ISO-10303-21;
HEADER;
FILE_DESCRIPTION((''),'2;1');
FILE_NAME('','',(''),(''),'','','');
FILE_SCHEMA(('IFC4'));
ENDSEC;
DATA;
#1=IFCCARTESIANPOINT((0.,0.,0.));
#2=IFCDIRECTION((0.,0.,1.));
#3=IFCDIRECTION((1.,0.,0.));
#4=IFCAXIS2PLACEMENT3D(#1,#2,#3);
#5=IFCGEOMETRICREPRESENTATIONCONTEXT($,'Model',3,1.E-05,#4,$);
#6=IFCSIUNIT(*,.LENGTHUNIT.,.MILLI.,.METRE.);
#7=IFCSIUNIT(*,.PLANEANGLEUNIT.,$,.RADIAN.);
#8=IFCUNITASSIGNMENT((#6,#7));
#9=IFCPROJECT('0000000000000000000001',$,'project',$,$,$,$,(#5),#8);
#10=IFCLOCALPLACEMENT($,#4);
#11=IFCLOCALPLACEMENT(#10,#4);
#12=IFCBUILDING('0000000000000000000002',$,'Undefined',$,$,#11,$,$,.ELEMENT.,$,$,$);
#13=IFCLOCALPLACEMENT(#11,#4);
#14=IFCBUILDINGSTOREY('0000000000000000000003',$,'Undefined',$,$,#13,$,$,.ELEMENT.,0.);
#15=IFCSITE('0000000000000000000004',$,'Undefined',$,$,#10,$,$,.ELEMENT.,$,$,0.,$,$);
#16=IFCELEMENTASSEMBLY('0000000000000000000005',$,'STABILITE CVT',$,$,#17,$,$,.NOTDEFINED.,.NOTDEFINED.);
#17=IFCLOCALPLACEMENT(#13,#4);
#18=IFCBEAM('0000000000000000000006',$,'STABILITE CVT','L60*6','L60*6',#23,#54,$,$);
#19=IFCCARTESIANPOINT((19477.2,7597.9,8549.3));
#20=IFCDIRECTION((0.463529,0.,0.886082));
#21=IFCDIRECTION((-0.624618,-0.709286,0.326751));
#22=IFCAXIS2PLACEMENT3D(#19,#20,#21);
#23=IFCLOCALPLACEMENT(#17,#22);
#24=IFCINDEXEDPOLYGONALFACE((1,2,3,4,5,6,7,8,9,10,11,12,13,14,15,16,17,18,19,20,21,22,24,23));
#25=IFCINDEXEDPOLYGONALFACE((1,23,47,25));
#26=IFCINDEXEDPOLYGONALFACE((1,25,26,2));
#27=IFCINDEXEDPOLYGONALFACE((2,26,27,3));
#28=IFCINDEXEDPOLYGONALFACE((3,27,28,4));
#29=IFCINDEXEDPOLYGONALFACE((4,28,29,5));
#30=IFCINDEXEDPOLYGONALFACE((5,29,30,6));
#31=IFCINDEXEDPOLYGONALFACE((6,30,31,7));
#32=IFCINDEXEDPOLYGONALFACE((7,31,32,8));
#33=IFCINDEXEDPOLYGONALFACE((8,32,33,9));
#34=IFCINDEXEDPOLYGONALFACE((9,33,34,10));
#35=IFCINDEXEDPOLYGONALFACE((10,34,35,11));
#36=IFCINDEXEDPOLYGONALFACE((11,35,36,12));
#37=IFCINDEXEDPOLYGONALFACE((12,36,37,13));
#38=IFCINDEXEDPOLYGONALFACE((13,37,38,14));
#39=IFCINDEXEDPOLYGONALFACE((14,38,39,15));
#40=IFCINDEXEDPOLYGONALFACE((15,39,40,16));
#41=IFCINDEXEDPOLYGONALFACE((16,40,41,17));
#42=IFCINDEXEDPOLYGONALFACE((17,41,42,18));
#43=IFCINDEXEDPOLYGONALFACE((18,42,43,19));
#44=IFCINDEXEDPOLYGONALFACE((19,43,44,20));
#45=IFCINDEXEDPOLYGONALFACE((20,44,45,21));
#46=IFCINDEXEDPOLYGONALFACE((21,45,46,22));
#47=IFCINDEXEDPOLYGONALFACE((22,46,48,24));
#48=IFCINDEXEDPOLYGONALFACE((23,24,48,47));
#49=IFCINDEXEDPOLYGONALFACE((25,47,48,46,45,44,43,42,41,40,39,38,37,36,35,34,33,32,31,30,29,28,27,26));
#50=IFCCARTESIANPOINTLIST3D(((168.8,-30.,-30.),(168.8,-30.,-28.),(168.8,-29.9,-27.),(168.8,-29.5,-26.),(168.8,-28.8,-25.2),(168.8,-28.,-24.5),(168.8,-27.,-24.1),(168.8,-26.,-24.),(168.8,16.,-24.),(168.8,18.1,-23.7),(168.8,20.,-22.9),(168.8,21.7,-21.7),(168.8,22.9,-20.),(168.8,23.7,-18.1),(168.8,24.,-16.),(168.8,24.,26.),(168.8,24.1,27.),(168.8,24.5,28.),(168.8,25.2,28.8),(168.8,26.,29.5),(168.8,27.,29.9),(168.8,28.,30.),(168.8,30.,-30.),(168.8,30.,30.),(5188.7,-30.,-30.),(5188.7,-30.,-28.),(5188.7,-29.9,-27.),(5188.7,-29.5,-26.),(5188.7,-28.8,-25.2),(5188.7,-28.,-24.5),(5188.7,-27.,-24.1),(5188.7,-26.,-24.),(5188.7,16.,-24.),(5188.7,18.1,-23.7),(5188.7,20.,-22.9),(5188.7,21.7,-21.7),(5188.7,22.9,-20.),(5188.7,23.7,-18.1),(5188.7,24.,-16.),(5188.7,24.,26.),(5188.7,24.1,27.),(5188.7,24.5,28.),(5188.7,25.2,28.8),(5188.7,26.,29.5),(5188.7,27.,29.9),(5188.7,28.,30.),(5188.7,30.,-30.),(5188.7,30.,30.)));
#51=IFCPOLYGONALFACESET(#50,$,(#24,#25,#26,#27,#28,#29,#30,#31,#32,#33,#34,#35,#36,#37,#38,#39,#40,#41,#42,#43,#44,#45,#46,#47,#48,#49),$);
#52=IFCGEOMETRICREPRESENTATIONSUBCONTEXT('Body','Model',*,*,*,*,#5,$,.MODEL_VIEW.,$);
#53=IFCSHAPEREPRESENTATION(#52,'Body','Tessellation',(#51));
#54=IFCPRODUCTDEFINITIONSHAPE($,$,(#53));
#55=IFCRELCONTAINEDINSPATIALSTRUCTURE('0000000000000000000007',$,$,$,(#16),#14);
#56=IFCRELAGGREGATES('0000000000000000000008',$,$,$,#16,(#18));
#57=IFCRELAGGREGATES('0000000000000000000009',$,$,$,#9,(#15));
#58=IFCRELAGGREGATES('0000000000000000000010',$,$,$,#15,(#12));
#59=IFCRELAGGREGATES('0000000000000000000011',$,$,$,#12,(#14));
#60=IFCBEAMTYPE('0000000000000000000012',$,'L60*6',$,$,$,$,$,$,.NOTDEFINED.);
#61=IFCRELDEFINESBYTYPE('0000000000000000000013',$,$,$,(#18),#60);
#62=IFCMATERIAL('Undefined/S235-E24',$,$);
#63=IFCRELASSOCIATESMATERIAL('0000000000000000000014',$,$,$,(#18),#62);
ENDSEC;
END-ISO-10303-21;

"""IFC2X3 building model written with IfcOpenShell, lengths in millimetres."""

from ifc_helpers import new_model, si_unit, frame, origin_with_axes, origin_2d_with_axis, place, context, subcontext, project, spatial, l_section, extrude, clip, halfspace, material, type_object, element, aggregate, save


model = new_model("IFC2X3")

# Units and contexts
model_context = context("Model", 3, precision=1e-05, world=origin_with_axes())
body_context = subcontext(model_context, "Body", "Model", "MODEL_VIEW")
ifc_project = project(units=[si_unit("LENGTHUNIT", "METRE", prefix="MILLI"), si_unit("PLANEANGLEUNIT", "RADIAN")], contexts=[model_context])

# Site, building, storey
site_placement = place(None, origin_with_axes())
site = spatial("IfcSite", under=ifc_project, at=site_placement, Name="Undefined", CompositionType="ELEMENT", RefElevation=0.0)
building_placement = place(site_placement, origin_with_axes())
building = spatial("IfcBuilding", under=site, at=building_placement, Name="Undefined", CompositionType="ELEMENT")
storey_placement = place(building_placement, origin_with_axes())
storey = spatial("IfcBuildingStorey", under=building, at=storey_placement, Name="Undefined", CompositionType="ELEMENT", Elevation=0.0)

# Element assembly, beam
assembly_1_placement = place(storey_placement, origin_with_axes())
assembly_1 = element("IfcElementAssembly", 1, at=assembly_1_placement, inside=storey, Name="STABILITE CVT", AssemblyPlace="NOTDEFINED", PredefinedType="NOTDEFINED")
ifc_material_1 = material(Name="Undefined/S235-E24")
beam_type_1 = type_object("IfcBeamType", Name="L60*6", PredefinedType="NOTDEFINED")
beam_1_placement = place(assembly_1_placement, frame((19477.2, 7597.9, 8549.3), z_axis=(0.463529, 0.0, 0.886082), x_axis=(-0.624618, -0.709286, 0.326751)))
beam_1 = element("IfcBeam", 2, at=beam_1_placement, type_object=beam_type_1, material=ifc_material_1, Name="STABILITE CVT", Description="L60*6", ObjectType="L60*6", context=body_context, shape_type="Clipping", body=[
    clip(clip(extrude(l_section(Depth=60.0, Width=60.0, Thickness=6.0, FilletRadius=8.0, EdgeRadius=4.0, at=origin_2d_with_axis()), frame((5278.6, 0.0, 0.0), z_axis=(-1.0, 0.0, 0.0), x_axis=(0.0, -1.0, 0.0)), (0.0, 0.0, 1.0), 5199.6), halfspace(frame((5188.7, 30.0, -30.0), z_axis=(-1.0, 0.0, 0.0), x_axis=(0.0, 0.0, 1.0)), True)), halfspace(frame((168.8, -30.0, -30.0), z_axis=(1.0, 0.0, 0.0), x_axis=(0.0, 0.0, 1.0)), True)),
])
aggregate(assembly_1, [beam_1])

save(model, "model.ifc")
